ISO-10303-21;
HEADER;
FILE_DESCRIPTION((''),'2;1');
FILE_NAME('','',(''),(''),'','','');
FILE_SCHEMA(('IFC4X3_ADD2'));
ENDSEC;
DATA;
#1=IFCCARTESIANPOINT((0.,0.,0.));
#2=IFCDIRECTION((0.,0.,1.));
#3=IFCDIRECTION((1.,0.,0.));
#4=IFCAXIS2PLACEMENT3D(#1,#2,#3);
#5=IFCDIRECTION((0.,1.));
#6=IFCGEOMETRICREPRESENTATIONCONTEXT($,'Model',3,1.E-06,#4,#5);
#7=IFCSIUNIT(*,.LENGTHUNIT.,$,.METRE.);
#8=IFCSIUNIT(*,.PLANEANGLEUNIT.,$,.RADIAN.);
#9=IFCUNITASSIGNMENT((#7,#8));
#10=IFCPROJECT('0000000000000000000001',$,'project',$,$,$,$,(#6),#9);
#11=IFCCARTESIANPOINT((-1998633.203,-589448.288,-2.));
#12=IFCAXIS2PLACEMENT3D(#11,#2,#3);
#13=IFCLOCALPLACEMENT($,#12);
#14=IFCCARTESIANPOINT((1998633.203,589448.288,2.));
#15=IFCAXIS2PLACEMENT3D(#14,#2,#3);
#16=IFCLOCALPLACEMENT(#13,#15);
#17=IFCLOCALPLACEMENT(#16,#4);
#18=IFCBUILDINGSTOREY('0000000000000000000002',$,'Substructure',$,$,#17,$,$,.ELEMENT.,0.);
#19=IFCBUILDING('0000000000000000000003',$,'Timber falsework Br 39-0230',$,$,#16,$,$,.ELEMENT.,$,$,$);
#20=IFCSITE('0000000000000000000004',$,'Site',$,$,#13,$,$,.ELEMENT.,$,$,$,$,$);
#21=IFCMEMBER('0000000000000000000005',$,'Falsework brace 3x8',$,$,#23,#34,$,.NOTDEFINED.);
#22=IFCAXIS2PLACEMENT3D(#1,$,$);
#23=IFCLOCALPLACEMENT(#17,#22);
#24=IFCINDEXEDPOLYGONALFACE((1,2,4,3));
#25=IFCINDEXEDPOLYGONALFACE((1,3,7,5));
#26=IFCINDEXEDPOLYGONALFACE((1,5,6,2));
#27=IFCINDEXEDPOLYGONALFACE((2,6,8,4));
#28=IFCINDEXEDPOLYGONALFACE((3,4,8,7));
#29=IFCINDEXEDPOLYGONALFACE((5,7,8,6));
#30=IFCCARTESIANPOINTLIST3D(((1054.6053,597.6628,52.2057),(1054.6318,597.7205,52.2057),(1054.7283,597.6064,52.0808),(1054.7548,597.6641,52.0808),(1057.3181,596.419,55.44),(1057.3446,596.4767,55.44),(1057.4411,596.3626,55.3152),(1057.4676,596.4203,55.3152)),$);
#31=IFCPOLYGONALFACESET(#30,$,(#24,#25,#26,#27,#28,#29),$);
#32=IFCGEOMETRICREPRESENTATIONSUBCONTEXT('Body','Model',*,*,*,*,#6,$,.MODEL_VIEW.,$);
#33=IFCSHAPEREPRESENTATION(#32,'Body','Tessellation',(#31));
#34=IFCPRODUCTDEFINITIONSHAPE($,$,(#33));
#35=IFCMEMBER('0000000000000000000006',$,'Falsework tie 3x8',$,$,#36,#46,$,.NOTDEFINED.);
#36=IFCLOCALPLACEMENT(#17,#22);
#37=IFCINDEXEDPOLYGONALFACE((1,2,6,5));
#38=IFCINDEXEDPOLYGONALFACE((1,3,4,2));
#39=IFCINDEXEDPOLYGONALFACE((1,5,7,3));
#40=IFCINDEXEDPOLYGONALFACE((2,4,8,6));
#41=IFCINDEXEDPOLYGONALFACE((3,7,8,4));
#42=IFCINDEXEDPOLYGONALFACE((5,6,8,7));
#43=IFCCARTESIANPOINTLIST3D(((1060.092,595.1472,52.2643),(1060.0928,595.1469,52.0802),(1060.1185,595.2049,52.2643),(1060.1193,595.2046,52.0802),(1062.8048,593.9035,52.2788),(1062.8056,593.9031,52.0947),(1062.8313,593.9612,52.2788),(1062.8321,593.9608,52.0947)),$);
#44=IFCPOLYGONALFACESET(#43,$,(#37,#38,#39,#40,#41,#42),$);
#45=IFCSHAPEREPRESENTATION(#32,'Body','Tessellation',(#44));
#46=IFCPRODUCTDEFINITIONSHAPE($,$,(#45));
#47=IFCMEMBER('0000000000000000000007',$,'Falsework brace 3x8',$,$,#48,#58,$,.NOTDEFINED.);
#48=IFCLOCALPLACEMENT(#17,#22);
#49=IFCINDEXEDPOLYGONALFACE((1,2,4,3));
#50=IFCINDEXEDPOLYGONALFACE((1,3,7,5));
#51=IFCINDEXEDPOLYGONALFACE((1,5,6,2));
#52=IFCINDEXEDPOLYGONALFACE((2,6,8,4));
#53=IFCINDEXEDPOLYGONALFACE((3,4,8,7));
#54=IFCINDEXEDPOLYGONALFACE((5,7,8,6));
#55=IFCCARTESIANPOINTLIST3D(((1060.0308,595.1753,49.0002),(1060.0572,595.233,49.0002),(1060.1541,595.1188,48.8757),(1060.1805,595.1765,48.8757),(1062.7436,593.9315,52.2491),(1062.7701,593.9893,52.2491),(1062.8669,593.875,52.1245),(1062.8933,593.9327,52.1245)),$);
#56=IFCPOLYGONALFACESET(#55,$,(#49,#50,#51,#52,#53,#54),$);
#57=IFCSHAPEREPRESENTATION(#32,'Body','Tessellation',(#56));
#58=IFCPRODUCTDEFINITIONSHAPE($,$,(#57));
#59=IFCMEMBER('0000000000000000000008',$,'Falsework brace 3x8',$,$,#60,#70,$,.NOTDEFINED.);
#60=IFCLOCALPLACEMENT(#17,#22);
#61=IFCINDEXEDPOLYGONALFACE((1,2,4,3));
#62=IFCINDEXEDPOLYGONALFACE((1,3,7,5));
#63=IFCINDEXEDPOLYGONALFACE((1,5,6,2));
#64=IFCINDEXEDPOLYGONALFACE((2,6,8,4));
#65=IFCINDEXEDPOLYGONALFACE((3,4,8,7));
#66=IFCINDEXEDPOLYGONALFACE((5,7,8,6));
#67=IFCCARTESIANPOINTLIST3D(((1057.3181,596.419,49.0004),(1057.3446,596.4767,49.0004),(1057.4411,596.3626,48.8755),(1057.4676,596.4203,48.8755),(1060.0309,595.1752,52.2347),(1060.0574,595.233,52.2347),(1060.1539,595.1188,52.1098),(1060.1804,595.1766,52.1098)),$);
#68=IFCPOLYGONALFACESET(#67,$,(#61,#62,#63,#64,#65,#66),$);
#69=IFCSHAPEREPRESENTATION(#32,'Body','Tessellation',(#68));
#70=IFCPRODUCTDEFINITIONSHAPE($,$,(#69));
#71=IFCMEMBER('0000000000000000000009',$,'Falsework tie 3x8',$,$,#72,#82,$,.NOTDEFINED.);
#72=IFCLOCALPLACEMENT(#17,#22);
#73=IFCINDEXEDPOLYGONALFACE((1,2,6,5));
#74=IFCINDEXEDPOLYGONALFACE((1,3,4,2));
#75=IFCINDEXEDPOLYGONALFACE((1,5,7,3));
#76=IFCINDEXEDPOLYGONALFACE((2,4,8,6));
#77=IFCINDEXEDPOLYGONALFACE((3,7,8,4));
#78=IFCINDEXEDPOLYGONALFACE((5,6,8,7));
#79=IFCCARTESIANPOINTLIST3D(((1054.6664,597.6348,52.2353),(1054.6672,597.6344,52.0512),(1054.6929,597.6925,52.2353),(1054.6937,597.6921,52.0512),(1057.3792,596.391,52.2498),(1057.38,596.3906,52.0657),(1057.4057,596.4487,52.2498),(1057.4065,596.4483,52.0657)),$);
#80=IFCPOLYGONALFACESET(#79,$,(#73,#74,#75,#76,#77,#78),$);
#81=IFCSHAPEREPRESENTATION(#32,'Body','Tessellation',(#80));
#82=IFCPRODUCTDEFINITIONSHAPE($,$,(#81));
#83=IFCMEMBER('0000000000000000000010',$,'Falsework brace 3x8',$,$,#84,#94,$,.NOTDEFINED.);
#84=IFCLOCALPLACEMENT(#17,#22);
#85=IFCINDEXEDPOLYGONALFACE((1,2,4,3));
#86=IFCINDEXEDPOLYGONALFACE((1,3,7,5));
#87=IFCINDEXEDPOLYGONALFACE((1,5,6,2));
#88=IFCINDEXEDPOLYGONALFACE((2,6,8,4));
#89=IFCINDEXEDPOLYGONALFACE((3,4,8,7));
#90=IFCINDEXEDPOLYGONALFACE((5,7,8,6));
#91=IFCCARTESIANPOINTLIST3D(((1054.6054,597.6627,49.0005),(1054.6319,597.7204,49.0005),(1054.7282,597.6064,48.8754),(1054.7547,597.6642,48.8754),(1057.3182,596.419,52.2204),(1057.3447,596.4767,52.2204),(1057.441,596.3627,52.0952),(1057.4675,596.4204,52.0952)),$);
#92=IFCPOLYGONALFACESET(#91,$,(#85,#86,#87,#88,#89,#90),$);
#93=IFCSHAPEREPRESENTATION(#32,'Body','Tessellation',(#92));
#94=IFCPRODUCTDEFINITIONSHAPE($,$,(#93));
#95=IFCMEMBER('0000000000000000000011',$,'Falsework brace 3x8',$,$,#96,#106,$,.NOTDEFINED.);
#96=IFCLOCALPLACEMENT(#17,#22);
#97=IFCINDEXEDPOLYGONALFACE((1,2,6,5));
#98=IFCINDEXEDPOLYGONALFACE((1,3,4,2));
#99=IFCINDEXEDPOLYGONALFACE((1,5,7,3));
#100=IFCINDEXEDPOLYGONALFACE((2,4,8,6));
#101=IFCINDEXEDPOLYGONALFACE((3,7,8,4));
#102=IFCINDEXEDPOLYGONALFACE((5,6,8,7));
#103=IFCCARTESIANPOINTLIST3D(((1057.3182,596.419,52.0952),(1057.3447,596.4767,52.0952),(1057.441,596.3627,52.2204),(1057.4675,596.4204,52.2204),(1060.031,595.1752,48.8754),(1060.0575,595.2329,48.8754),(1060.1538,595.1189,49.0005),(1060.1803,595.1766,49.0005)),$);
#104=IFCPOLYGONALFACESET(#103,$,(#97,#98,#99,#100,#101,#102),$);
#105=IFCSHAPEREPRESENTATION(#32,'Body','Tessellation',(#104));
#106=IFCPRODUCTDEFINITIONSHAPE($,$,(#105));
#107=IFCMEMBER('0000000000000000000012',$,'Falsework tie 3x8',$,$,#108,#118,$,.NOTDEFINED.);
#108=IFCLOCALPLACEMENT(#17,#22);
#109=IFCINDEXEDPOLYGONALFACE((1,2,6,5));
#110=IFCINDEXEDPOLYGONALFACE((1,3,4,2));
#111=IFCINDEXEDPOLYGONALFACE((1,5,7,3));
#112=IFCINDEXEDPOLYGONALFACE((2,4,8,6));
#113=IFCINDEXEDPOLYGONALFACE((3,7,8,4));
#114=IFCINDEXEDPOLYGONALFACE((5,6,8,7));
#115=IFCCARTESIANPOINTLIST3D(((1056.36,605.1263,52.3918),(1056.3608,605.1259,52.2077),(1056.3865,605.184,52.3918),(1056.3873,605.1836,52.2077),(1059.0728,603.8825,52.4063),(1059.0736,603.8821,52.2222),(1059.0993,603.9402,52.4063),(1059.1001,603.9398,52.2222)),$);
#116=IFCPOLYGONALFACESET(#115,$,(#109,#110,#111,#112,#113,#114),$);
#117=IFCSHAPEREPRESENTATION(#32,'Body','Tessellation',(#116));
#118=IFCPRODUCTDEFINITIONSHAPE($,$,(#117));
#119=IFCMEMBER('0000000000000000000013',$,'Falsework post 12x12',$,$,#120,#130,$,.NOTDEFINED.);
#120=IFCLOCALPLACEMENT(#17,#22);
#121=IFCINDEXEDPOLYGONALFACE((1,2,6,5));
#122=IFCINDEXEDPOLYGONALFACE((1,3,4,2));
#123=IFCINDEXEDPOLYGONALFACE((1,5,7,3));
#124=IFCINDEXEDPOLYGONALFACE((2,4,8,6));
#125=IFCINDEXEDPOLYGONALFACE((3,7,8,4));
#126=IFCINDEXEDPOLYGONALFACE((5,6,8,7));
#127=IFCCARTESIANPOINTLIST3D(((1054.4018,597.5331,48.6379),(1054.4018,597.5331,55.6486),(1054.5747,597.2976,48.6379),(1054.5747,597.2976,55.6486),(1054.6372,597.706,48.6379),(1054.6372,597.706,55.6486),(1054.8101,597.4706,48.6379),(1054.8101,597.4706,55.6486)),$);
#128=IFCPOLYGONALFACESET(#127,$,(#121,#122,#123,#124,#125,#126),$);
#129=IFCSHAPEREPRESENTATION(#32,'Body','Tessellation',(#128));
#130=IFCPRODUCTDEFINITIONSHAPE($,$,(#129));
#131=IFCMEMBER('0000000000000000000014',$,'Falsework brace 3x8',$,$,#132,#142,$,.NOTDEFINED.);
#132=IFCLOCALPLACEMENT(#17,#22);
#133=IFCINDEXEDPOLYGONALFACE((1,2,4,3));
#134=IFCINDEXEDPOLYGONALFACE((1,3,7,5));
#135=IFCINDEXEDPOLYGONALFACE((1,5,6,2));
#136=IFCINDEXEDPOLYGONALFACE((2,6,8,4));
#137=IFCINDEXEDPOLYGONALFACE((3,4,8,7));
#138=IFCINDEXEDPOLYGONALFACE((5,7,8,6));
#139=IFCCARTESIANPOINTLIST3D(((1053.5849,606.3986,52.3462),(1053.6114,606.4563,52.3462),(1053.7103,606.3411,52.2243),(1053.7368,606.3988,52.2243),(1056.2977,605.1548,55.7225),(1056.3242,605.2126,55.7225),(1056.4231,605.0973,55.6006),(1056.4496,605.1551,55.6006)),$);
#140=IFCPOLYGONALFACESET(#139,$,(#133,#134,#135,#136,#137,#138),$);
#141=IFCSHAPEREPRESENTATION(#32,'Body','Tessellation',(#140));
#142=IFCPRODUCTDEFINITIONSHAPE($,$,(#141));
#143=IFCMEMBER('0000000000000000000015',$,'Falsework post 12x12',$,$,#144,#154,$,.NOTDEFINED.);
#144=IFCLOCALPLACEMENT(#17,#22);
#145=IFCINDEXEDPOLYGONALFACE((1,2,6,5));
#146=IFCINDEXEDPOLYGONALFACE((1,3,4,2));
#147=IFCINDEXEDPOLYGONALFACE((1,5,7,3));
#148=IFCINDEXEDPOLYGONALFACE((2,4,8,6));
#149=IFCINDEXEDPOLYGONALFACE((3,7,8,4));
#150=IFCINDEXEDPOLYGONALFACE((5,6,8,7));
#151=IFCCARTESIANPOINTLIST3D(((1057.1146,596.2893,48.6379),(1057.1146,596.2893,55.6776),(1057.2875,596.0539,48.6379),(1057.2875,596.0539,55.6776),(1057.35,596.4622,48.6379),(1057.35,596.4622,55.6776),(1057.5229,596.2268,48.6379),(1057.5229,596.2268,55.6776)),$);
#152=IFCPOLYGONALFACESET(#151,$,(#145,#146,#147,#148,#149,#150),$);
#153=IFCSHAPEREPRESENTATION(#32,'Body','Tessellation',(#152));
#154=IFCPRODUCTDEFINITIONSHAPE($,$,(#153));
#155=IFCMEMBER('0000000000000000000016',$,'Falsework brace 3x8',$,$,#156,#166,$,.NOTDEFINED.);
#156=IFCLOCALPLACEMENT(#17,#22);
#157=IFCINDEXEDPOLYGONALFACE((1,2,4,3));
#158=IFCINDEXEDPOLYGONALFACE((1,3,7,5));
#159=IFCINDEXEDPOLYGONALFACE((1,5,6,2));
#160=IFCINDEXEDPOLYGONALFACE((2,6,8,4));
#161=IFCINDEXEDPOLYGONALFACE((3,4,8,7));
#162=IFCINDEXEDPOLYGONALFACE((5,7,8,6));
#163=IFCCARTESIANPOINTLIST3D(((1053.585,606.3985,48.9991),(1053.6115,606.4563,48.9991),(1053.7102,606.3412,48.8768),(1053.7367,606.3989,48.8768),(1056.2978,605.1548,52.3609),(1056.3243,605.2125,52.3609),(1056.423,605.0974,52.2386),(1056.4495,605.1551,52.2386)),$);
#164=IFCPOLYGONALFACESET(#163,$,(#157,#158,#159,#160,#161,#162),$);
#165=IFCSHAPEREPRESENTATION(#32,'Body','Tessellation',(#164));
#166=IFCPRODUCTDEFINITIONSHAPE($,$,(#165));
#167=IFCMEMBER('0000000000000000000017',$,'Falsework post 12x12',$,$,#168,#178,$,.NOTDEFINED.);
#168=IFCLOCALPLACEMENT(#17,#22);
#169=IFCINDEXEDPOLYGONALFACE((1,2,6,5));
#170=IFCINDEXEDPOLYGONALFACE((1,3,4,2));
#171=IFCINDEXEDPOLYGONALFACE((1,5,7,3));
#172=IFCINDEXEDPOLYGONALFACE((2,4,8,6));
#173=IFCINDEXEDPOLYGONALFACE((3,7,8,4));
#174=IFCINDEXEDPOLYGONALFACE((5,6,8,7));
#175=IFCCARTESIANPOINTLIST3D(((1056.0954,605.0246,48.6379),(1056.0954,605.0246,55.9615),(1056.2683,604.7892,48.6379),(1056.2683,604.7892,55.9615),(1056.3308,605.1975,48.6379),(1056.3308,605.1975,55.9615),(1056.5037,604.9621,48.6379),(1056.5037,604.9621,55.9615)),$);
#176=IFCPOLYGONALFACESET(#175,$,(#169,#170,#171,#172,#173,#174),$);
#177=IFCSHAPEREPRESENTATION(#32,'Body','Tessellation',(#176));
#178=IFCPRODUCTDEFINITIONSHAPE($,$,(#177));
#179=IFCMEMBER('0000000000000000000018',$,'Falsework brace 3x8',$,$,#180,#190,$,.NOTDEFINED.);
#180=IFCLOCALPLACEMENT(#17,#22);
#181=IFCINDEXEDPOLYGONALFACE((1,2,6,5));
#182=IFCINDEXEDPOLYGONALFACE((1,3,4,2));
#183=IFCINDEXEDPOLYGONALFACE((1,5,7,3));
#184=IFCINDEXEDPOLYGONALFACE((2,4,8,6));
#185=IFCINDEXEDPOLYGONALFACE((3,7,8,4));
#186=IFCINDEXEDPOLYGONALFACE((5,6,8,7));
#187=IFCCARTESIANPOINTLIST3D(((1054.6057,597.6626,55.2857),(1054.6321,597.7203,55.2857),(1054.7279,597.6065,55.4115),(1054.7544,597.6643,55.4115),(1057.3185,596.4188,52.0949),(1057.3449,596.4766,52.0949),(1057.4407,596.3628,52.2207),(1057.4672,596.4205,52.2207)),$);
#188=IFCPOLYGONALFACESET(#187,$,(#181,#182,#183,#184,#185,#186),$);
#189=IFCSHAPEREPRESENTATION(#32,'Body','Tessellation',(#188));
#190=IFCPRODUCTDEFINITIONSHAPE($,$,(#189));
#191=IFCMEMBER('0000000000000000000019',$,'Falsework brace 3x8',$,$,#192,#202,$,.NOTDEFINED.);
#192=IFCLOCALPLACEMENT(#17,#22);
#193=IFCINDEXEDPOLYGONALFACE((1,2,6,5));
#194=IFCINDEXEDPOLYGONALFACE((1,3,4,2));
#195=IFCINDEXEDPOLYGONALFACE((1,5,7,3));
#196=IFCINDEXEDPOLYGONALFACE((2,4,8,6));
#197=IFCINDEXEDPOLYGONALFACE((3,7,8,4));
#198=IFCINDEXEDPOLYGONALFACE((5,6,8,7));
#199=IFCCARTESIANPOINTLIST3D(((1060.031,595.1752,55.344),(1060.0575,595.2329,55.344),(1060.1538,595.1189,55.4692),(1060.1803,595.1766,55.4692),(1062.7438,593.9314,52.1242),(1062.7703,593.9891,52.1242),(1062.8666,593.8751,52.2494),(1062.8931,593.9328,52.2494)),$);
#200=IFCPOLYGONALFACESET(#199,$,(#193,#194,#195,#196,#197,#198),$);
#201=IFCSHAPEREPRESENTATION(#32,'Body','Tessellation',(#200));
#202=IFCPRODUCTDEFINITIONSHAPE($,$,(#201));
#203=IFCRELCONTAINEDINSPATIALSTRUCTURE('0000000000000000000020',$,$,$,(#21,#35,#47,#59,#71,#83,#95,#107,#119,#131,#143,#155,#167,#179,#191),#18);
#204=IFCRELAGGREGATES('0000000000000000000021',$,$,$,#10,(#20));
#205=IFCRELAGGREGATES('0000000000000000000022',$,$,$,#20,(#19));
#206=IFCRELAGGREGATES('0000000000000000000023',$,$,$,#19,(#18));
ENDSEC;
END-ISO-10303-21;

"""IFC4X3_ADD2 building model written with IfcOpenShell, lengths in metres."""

from ifc_helpers import new_model, si_unit, direction, frame, origin, origin_with_axes, origin_2d, place, context, subcontext, project, spatial, rectangle, extrude, element, save


model = new_model("IFC4X3_ADD2")

# Units and contexts
model_context = context("Model", 3, precision=1e-06, world=origin_with_axes(), true_north=direction((0.0, 1.0)))
body_context = subcontext(model_context, "Body", "Model", "MODEL_VIEW")
ifc_project = project(units=[si_unit("LENGTHUNIT", "METRE"), si_unit("PLANEANGLEUNIT", "RADIAN")], contexts=[model_context])

# Site, building, storey
site_placement = place(None, frame((-1998633.203, -589448.288, -2.0), z_axis=(0.0, 0.0, 1.0), x_axis=(1.0, 0.0, 0.0)))
site = spatial("IfcSite", under=ifc_project, at=site_placement, Name="Site", CompositionType="ELEMENT")
building_placement = place(site_placement, frame((1998633.203, 589448.288, 2.0), z_axis=(0.0, 0.0, 1.0), x_axis=(1.0, 0.0, 0.0)))
building = spatial("IfcBuilding", under=site, at=building_placement, Name="Timber falsework Br 39-0230", CompositionType="ELEMENT")
storey_placement = place(building_placement, origin_with_axes())
storey = spatial("IfcBuildingStorey", under=building, at=storey_placement, Name="Substructure", CompositionType="ELEMENT", Elevation=0.0)

# Members
member_1_placement = place(storey_placement, frame((1054.68, 597.6634, 52.1433), z_axis=(0.616432, -0.282622, 0.734939), x_axis=(0.416765, 0.909014, 0.0)))
element("IfcMember", 1, at=member_1_placement, inside=storey, Name="Falsework brace 3x8", PredefinedType="NOTDEFINED", context=body_context, shape_type="SweptSolid", body=[
    extrude(rectangle(XDim=0.0635, YDim=0.1841, at=origin_2d()), origin(), (0.0, 0.0, 1.0), 4.4008),
])
member_2_placement = place(storey_placement, frame((1060.1057, 595.1759, 52.1723), z_axis=(0.909003, -0.41676, 0.004859), x_axis=(0.416765, 0.909014, 0.0)))
element("IfcMember", 2, at=member_2_placement, inside=storey, Name="Falsework tie 3x8", PredefinedType="NOTDEFINED", context=body_context, shape_type="SweptSolid", body=[
    extrude(rectangle(XDim=0.0635, YDim=0.1841, at=origin_2d()), origin(), (0.0, 0.0, 1.0), 2.9844),
])
member_3_placement = place(storey_placement, frame((1060.1057, 595.1759, 48.9379), z_axis=(0.614942, -0.281939, 0.736449), x_axis=(0.416765, 0.909014, 0.0)))
element("IfcMember", 3, at=member_3_placement, inside=storey, Name="Falsework brace 3x8", PredefinedType="NOTDEFINED", context=body_context, shape_type="SweptSolid", body=[
    extrude(rectangle(XDim=0.0635, YDim=0.1841, at=origin_2d()), origin(), (0.0, 0.0, 1.0), 4.4115),
])
member_4_placement = place(storey_placement, frame((1057.3928, 596.4197, 48.9379), z_axis=(0.616432, -0.282622, 0.734939), x_axis=(0.416765, 0.909014, 0.0)))
element("IfcMember", 4, at=member_4_placement, inside=storey, Name="Falsework brace 3x8", PredefinedType="NOTDEFINED", context=body_context, shape_type="SweptSolid", body=[
    extrude(rectangle(XDim=0.0635, YDim=0.1841, at=origin_2d()), origin(), (0.0, 0.0, 1.0), 4.4008),
])
member_5_placement = place(storey_placement, frame((1054.68, 597.6634, 52.1433), z_axis=(0.909003, -0.41676, 0.004859), x_axis=(0.416765, 0.909014, 0.0)))
element("IfcMember", 5, at=member_5_placement, inside=storey, Name="Falsework tie 3x8", PredefinedType="NOTDEFINED", context=body_context, shape_type="SweptSolid", body=[
    extrude(rectangle(XDim=0.0635, YDim=0.1841, at=origin_2d()), origin(), (0.0, 0.0, 1.0), 2.9844),
])
for number, where, z_axis, x_axis, name in (
    (6, (1054.68, 597.6634, 48.9379), (0.617927, -0.283308, 0.733419), (0.416765, 0.909014, 0.0), "Falsework brace 3x8"),
    (7, (1057.3928, 596.4197, 52.1578), (0.617927, -0.283308, -0.733419), (0.416765, 0.909014, 0.0), "Falsework brace 3x8"),
):
    element("IfcMember", number, at=place(storey_placement, frame(where, z_axis=z_axis, x_axis=x_axis)), inside=storey, Name=name, PredefinedType="NOTDEFINED", context=body_context, shape_type="SweptSolid", body=[
        extrude(rectangle(XDim=0.0635, YDim=0.1841, at=origin_2d()), origin(), (0.0, 0.0, 1.0), 4.3902),
    ])
member_6_placement = place(storey_placement, frame((1056.3737, 605.1549, 52.2997), z_axis=(0.909003, -0.41676, 0.004859), x_axis=(0.416765, 0.909014, 0.0)))
element("IfcMember", 8, at=member_6_placement, inside=storey, Name="Falsework tie 3x8", PredefinedType="NOTDEFINED", context=body_context, shape_type="SweptSolid", body=[
    extrude(rectangle(XDim=0.0635, YDim=0.1841, at=origin_2d()), origin(), (0.0, 0.0, 1.0), 2.9844),
])
member_7_placement = place(storey_placement, frame((1054.6059, 597.5018, 48.6379), z_axis=(0.0, 0.0, 1.0), x_axis=(-0.805928, -0.592013, 0.0)))
element("IfcMember", 9, at=member_7_placement, inside=storey, Name="Falsework post 12x12", PredefinedType="NOTDEFINED", context=body_context, shape_type="SweptSolid", body=[
    extrude(rectangle(XDim=0.2921, YDim=0.2921, at=origin_2d()), origin(), (0.0, 0.0, 1.0), 7.0107),
])
member_8_placement = place(storey_placement, frame((1053.6608, 606.3987, 52.2852), z_axis=(0.602019, -0.276014, 0.74926), x_axis=(0.416765, 0.909014, 0.0)))
element("IfcMember", 10, at=member_8_placement, inside=storey, Name="Falsework brace 3x8", PredefinedType="NOTDEFINED", context=body_context, shape_type="SweptSolid", body=[
    extrude(rectangle(XDim=0.0635, YDim=0.1841, at=origin_2d()), origin(), (0.0, 0.0, 1.0), 4.5062),
])
member_9_placement = place(storey_placement, frame((1057.3187, 596.258, 48.6379), z_axis=(0.0, 0.0, 1.0), x_axis=(-0.805928, -0.592013, 0.0)))
element("IfcMember", 11, at=member_9_placement, inside=storey, Name="Falsework post 12x12", PredefinedType="NOTDEFINED", context=body_context, shape_type="SweptSolid", body=[
    extrude(rectangle(XDim=0.2921, YDim=0.2921, at=origin_2d()), origin(), (0.0, 0.0, 1.0), 7.0397),
])
member_10_placement = place(storey_placement, frame((1053.6608, 606.3987, 48.9379), z_axis=(0.603472, -0.27668, 0.747843), x_axis=(0.416765, 0.909014, 0.0)))
element("IfcMember", 12, at=member_10_placement, inside=storey, Name="Falsework brace 3x8", PredefinedType="NOTDEFINED", context=body_context, shape_type="SweptSolid", body=[
    extrude(rectangle(XDim=0.0635, YDim=0.1841, at=origin_2d()), origin(), (0.0, 0.0, 1.0), 4.4953),
])
member_11_placement = place(storey_placement, frame((1056.2995, 604.9933, 48.6379), z_axis=(0.0, 0.0, 1.0), x_axis=(-0.805928, -0.592013, 0.0)))
element("IfcMember", 13, at=member_11_placement, inside=storey, Name="Falsework post 12x12", PredefinedType="NOTDEFINED", context=body_context, shape_type="SweptSolid", body=[
    extrude(rectangle(XDim=0.2921, YDim=0.2921, at=origin_2d()), origin(), (0.0, 0.0, 1.0), 7.3236),
])
member_12_placement = place(storey_placement, frame((1054.68, 597.6634, 55.3486), z_axis=(0.620929, -0.284684, -0.730344), x_axis=(0.416765, 0.909014, 0.0)))
element("IfcMember", 14, at=member_12_placement, inside=storey, Name="Falsework brace 3x8", PredefinedType="NOTDEFINED", context=body_context, shape_type="SweptSolid", body=[
    extrude(rectangle(XDim=0.0635, YDim=0.1841, at=origin_2d()), origin(), (0.0, 0.0, 1.0), 4.3689),
])
member_13_placement = place(storey_placement, frame((1060.1057, 595.1759, 55.4066), z_axis=(0.617927, -0.283308, -0.733419), x_axis=(0.416765, 0.909014, 0.0)))
element("IfcMember", 15, at=member_13_placement, inside=storey, Name="Falsework brace 3x8", PredefinedType="NOTDEFINED", context=body_context, shape_type="SweptSolid", body=[
    extrude(rectangle(XDim=0.0635, YDim=0.1841, at=origin_2d()), origin(), (0.0, 0.0, 1.0), 4.3902),
])

save(model, "model.ifc")
